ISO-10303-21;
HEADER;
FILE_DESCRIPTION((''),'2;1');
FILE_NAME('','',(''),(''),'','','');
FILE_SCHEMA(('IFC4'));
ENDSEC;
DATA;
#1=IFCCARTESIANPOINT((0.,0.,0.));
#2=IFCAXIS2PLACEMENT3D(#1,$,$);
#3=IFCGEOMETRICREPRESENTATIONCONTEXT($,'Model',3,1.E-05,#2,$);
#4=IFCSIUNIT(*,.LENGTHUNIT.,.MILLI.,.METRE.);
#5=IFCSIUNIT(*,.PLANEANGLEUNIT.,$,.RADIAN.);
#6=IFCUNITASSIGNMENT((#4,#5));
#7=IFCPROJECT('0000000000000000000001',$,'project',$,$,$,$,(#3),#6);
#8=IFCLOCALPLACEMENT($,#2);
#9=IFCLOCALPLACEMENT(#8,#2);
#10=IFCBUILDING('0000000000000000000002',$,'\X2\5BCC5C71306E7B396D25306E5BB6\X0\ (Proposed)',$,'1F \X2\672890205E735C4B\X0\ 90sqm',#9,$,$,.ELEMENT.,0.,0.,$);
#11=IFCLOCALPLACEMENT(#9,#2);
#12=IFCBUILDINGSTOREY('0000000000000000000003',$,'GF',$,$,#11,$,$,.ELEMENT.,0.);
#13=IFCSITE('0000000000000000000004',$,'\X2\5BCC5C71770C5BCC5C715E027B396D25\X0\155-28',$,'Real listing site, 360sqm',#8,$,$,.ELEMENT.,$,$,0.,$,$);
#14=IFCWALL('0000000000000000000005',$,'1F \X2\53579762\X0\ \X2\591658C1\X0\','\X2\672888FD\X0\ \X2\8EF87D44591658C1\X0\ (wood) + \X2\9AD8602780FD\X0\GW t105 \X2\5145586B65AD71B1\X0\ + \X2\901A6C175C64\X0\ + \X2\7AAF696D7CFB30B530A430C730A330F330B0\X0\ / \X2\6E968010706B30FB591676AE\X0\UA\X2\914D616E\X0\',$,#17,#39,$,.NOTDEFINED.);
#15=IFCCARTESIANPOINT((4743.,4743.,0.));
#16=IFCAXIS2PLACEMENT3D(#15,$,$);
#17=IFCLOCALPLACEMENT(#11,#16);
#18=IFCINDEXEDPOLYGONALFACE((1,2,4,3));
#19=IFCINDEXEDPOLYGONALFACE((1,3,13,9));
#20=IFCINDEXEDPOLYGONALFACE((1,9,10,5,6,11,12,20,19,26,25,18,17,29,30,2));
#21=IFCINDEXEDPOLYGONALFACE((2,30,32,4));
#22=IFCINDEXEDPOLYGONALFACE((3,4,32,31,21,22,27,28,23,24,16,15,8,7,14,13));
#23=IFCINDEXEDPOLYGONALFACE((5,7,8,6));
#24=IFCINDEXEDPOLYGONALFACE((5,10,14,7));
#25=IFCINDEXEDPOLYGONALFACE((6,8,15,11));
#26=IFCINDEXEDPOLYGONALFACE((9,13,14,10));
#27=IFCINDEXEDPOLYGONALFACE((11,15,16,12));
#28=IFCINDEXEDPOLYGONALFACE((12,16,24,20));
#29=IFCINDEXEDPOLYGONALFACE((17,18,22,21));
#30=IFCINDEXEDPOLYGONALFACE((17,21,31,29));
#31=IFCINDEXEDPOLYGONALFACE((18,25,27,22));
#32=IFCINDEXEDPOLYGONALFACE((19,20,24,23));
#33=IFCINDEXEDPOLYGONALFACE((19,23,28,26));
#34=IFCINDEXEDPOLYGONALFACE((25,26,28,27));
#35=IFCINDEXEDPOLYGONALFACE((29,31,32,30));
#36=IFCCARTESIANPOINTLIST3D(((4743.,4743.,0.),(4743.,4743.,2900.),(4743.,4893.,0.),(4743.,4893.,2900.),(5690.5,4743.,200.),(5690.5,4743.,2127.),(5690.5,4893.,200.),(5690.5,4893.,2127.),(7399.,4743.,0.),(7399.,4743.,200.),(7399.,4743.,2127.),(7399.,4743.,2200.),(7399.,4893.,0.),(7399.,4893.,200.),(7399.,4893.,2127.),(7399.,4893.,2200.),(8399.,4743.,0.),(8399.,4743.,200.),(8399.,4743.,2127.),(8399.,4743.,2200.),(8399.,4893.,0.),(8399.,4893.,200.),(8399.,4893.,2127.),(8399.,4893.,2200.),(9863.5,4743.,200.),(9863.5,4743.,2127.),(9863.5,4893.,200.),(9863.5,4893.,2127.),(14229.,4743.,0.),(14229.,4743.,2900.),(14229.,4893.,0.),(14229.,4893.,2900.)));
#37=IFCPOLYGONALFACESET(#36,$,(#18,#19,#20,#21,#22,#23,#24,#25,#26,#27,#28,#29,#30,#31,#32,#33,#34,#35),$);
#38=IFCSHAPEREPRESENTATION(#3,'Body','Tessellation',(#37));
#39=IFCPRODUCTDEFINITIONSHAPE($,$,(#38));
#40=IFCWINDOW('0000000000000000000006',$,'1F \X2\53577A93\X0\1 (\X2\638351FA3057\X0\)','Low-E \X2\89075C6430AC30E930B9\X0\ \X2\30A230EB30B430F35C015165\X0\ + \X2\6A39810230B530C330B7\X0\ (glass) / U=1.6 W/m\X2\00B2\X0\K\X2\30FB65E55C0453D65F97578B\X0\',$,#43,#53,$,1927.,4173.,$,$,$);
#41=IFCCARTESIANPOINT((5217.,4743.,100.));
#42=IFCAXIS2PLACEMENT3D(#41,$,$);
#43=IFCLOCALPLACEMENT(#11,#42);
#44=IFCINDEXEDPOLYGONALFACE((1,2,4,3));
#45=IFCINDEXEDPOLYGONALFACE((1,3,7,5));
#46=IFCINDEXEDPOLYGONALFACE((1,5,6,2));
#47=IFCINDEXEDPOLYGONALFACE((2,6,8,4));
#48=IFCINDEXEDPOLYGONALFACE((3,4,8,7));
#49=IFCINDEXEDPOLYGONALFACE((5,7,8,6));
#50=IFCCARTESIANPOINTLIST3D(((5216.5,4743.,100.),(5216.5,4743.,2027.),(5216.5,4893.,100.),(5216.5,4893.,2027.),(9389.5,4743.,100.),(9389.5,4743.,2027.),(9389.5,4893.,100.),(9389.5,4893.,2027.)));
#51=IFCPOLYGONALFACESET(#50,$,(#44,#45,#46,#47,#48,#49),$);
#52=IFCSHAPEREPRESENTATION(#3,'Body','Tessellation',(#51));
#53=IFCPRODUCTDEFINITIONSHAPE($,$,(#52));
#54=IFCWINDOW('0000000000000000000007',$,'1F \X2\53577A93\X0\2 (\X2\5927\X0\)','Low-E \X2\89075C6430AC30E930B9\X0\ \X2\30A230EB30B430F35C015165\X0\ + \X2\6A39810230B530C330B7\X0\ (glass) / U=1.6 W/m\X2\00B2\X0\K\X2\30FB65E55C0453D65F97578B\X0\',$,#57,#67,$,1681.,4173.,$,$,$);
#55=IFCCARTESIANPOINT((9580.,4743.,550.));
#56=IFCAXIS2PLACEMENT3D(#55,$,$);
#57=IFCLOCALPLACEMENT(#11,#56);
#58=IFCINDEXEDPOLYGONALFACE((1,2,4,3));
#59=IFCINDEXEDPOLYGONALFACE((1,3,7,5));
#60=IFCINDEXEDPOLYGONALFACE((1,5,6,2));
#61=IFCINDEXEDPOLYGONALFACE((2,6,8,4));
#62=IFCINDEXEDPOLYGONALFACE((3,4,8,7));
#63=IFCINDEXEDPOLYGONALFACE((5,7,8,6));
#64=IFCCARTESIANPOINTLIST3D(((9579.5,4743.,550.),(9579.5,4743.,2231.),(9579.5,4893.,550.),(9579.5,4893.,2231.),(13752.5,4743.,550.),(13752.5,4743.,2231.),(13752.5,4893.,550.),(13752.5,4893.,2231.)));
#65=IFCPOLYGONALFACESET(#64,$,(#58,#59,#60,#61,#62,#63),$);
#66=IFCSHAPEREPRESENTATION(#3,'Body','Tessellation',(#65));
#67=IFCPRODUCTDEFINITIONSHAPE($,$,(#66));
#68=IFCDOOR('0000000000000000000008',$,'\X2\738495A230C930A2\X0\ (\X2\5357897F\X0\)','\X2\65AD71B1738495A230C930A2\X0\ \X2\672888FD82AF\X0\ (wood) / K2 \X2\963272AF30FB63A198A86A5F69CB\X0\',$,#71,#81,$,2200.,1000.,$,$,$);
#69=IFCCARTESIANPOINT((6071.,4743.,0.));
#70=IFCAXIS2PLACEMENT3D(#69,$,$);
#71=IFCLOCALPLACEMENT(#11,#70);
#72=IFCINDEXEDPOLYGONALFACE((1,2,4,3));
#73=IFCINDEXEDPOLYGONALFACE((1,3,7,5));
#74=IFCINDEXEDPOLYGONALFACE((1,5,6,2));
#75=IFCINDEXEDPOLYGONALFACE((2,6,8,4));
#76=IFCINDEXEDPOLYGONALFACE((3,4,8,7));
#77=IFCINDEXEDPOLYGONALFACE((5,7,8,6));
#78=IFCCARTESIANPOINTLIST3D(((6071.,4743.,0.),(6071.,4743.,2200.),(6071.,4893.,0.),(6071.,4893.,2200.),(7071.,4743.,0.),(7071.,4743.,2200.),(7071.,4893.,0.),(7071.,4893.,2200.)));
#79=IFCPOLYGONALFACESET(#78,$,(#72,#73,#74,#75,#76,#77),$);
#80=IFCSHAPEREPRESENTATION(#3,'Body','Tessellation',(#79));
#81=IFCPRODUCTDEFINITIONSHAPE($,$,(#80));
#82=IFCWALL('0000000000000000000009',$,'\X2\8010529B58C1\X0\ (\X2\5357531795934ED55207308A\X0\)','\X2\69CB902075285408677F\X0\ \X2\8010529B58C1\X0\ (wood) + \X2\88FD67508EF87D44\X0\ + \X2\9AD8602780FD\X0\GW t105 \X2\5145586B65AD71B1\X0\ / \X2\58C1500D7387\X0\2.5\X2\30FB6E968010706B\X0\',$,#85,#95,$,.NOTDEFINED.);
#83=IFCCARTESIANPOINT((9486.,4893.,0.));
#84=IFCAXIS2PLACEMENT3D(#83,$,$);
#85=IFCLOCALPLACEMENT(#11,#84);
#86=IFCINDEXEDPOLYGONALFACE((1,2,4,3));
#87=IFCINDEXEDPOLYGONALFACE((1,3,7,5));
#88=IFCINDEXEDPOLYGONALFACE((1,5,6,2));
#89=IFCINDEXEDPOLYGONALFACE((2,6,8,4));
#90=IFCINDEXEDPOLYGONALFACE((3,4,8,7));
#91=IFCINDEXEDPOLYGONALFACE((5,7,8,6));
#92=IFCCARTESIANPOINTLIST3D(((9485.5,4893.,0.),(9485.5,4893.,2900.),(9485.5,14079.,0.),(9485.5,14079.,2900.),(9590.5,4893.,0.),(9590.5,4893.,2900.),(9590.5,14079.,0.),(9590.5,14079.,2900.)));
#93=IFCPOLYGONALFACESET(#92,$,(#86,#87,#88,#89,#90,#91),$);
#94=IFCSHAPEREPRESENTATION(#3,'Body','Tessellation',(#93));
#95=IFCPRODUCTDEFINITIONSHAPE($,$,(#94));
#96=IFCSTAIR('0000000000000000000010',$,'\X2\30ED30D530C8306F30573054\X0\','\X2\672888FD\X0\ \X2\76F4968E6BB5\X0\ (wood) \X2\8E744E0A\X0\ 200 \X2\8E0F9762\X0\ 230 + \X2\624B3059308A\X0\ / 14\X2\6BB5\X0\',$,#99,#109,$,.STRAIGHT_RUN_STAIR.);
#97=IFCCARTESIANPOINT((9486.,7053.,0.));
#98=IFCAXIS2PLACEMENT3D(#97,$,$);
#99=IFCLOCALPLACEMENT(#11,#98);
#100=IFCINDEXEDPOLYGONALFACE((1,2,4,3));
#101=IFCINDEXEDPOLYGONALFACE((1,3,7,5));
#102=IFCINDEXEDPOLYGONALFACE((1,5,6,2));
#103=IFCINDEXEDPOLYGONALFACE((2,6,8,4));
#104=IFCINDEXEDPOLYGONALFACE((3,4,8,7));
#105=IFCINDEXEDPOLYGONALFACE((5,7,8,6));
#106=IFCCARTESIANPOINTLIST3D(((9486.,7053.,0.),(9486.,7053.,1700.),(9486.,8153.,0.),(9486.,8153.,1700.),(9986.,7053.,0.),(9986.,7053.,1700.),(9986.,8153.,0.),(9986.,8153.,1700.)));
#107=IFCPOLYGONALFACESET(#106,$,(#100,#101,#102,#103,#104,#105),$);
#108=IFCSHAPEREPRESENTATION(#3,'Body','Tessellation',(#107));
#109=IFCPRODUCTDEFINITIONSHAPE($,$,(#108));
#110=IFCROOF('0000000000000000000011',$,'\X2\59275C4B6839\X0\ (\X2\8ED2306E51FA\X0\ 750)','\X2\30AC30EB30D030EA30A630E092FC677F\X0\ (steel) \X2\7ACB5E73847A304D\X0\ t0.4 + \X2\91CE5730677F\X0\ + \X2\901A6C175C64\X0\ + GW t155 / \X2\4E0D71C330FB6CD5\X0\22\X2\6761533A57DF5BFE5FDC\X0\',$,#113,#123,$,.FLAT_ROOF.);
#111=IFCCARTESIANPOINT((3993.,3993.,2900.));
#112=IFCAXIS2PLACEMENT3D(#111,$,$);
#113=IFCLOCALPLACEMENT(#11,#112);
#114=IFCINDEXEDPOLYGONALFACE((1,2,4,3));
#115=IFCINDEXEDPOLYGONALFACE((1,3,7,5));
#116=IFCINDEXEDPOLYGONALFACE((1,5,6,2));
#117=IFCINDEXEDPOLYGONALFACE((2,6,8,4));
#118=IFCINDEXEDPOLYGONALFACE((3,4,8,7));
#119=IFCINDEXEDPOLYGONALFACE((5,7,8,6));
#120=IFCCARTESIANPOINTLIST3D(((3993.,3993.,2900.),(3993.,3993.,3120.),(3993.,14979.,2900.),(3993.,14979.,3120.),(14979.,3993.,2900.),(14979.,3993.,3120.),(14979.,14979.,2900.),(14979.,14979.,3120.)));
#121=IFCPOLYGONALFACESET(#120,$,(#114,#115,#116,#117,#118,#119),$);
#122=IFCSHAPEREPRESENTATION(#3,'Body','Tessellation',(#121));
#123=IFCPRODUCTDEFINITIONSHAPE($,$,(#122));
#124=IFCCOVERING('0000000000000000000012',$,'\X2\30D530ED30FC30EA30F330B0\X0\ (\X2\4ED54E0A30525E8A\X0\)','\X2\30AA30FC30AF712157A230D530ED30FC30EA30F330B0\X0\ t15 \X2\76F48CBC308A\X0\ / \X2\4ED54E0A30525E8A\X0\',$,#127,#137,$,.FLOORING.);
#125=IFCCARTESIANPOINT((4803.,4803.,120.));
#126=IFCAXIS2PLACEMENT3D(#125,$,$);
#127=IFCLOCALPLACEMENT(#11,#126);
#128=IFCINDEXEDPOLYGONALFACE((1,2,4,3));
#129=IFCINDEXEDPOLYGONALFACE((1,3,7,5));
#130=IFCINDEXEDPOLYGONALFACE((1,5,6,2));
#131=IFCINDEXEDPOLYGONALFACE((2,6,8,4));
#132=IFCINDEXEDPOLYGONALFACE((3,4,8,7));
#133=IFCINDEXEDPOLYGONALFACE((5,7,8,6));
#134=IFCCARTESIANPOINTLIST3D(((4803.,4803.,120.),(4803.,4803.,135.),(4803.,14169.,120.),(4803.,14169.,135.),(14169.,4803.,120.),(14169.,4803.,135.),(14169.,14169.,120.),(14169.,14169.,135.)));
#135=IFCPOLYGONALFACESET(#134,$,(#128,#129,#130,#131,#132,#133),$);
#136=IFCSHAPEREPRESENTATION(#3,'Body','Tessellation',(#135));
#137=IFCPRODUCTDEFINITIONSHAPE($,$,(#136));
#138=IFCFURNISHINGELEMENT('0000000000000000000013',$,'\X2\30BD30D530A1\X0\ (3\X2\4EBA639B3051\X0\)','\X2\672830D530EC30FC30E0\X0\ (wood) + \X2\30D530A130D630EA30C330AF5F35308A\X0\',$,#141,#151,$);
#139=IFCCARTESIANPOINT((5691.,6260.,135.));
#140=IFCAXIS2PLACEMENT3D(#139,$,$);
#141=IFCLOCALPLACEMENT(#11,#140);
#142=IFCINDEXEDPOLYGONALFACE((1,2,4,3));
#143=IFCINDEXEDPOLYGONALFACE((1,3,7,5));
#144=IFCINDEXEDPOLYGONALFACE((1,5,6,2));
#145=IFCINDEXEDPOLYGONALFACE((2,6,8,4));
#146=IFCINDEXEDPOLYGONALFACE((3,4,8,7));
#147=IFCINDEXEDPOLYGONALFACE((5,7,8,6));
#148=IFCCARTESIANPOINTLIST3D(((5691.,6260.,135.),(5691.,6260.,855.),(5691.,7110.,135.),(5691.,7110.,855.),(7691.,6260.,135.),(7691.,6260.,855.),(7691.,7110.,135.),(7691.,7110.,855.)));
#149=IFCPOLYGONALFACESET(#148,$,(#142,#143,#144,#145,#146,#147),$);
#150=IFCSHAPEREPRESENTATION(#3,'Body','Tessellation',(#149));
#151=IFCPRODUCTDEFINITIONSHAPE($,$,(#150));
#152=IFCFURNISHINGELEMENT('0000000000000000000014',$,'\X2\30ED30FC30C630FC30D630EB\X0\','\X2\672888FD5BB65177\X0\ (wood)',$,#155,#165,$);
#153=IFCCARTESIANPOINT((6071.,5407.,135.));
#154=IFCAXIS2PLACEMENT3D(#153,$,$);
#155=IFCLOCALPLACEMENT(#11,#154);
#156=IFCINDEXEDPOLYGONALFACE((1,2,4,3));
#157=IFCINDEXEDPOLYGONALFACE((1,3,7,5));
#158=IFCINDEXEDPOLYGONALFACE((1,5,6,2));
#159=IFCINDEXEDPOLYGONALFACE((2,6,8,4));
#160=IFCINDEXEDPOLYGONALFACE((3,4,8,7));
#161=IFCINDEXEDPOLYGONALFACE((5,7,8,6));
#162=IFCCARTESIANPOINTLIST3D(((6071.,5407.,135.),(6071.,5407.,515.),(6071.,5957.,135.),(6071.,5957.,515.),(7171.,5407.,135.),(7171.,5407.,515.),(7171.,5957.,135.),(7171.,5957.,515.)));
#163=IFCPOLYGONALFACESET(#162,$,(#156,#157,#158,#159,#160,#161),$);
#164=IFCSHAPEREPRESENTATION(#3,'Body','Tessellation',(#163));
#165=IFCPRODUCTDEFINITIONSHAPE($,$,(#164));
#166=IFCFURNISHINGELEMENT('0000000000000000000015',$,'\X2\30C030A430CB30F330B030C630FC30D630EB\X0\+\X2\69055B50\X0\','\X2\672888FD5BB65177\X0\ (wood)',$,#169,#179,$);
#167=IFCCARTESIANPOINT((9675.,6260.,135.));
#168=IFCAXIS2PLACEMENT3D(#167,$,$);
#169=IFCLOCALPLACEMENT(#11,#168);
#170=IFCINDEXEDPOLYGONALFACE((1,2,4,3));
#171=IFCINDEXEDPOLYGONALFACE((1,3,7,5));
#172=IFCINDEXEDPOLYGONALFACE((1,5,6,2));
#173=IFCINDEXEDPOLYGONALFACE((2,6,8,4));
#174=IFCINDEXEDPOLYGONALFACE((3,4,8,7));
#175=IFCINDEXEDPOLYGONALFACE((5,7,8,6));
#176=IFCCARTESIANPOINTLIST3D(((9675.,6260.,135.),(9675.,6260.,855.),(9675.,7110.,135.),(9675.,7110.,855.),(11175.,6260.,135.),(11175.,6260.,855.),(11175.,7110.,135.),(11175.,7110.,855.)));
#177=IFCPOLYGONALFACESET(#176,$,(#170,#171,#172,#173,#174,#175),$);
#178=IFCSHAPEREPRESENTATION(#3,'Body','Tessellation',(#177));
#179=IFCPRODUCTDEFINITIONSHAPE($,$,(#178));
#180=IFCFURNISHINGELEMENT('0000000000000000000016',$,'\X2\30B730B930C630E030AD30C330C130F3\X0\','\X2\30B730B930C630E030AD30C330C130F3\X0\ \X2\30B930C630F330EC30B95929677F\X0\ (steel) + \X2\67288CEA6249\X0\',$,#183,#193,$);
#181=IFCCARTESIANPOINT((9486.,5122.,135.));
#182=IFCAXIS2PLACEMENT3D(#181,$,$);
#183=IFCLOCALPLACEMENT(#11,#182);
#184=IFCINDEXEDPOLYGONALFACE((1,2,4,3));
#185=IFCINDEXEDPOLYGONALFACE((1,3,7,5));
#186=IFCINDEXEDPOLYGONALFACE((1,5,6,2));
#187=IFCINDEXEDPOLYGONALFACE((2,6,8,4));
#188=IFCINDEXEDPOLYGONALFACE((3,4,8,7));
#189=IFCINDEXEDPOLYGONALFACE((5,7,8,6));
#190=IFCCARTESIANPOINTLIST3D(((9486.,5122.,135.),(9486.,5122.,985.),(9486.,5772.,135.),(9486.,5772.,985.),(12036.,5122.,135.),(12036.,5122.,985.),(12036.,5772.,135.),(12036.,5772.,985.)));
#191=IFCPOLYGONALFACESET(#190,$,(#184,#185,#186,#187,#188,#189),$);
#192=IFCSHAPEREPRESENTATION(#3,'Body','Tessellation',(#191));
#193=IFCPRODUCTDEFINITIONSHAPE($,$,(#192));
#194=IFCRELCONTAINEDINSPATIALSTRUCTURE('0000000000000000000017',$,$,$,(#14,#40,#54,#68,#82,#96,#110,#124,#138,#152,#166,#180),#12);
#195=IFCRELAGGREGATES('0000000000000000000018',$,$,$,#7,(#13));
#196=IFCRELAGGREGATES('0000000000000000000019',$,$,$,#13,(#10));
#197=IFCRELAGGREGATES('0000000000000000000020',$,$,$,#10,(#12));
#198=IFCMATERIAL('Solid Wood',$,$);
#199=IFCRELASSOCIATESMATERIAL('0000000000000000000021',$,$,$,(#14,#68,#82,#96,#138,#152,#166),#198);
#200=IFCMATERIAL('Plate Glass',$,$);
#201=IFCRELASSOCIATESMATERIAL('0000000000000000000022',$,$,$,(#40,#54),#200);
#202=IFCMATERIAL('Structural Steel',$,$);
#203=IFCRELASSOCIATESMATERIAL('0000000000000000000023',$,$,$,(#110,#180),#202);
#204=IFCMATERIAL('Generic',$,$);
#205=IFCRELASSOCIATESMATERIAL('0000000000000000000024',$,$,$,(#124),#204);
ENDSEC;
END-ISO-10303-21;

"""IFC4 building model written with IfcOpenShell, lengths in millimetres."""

from ifc_helpers import new_model, si_unit, frame, frame_2d, origin, place, context, project, spatial, rectangle, extrude, material, element, fill, save


model = new_model("IFC4")

# Units and contexts
model_context = context("Model", 3, precision=1e-05, world=origin())
ifc_project = project(units=[si_unit("LENGTHUNIT", "METRE", prefix="MILLI"), si_unit("PLANEANGLEUNIT", "RADIAN")], contexts=[model_context])

# Site, building, storey
site_placement = place(None, origin())
site = spatial("IfcSite", under=ifc_project, at=site_placement, Name="富山県富山市笹津155-28", ObjectType="Real listing site, 360sqm", CompositionType="ELEMENT", RefElevation=0.0)
building_placement = place(site_placement, origin())
building = spatial("IfcBuilding", under=site, at=building_placement, Name="富山の笹津の家 (Proposed)", ObjectType="1F 木造平屋 90sqm", CompositionType="ELEMENT", ElevationOfRefHeight=0.0, ElevationOfTerrain=0.0)
storey_placement = place(building_placement, origin())
storey = spatial("IfcBuildingStorey", under=building, at=storey_placement, Name="GF", CompositionType="ELEMENT", Elevation=0.0)

# Shared definitions
ifc_material_1 = material(Name="Solid Wood")

# Wall, openings, windows, door
wall_1_placement = place(storey_placement, frame((4743.0, 4743.0, 0.0)))
wall_1 = element("IfcWall", 1, at=wall_1_placement, inside=storey, material=ifc_material_1, Name="1F 南面 外壁", Description="木製 軸組外壁 (wood) + 高性能GW t105 充填断熱 + 通気層 + 窯業系サイディング / 準耐火・外皮UA配慮", PredefinedType="NOTDEFINED", context=model_context, shape_type="SweptSolid", body=[
    extrude(rectangle(XDim=9486.0, YDim=150.0, at=frame_2d((4743.0, 75.0))), frame((4743.0, 4743.0, 0.0)), (0.0, 0.0, 1.0), 2900.0),
])
opening_1_placement = place(storey_placement, frame((5217.0, 4743.0, 100.0)))
opening_1 = element("IfcOpeningElement", 2, at=opening_1_placement, cuts=wall_1, PredefinedType="NOTDEFINED", context=model_context, shape_type="SweptSolid", body=[
    extrude(rectangle(XDim=4173.0, YDim=150.0, at=frame_2d((2086.0, 75.0))), frame((5217.0, 4743.0, 100.0)), (0.0, 0.0, 1.0), 1927.0),
])
opening_2_placement = place(storey_placement, frame((9580.0, 4743.0, 550.0)))
opening_2 = element("IfcOpeningElement", 3, at=opening_2_placement, cuts=wall_1, PredefinedType="NOTDEFINED", context=model_context, shape_type="SweptSolid", body=[
    extrude(rectangle(XDim=4173.0, YDim=150.0, at=frame_2d((2086.0, 75.0))), frame((9580.0, 4743.0, 550.0)), (0.0, 0.0, 1.0), 1681.0),
])
opening_3_placement = place(storey_placement, frame((6071.0, 4743.0, 0.0)))
opening_3 = element("IfcOpeningElement", 4, at=opening_3_placement, cuts=wall_1, PredefinedType="NOTDEFINED", context=model_context, shape_type="SweptSolid", body=[
    extrude(rectangle(XDim=1000.0, YDim=150.0, at=frame_2d((500.0, 75.0))), frame((6071.0, 4743.0, 0.0)), (0.0, 0.0, 1.0), 2200.0),
])
ifc_material_2 = material(Name="Plate Glass")
window_1_placement = place(storey_placement, frame((5217.0, 4743.0, 100.0)))
window_1 = element("IfcWindow", 5, at=window_1_placement, inside=storey, material=ifc_material_2, Name="1F 南窓1 (掃出し)", Description="Low-E 複層ガラス アルゴン封入 + 樹脂サッシ (glass) / U=1.6 W/m²K・日射取得型", OverallHeight=1927.0, OverallWidth=4173.0, context=model_context, shape_type="SweptSolid", body=[
    extrude(rectangle(XDim=4173.0, YDim=150.0, at=frame_2d((2086.0, 75.0))), frame((5217.0, 4743.0, 100.0)), (0.0, 0.0, 1.0), 1927.0),
])
fill(opening_1, window_1)
window_2_placement = place(storey_placement, frame((9580.0, 4743.0, 550.0)))
window_2 = element("IfcWindow", 6, at=window_2_placement, inside=storey, material=ifc_material_2, Name="1F 南窓2 (大)", Description="Low-E 複層ガラス アルゴン封入 + 樹脂サッシ (glass) / U=1.6 W/m²K・日射取得型", OverallHeight=1681.0, OverallWidth=4173.0, context=model_context, shape_type="SweptSolid", body=[
    extrude(rectangle(XDim=4173.0, YDim=150.0, at=frame_2d((2086.0, 75.0))), frame((9580.0, 4743.0, 550.0)), (0.0, 0.0, 1.0), 1681.0),
])
fill(opening_2, window_2)
door_placement = place(storey_placement, frame((6071.0, 4743.0, 0.0)))
door = element("IfcDoor", 7, at=door_placement, inside=storey, material=ifc_material_1, Name="玄関ドア (南西)", Description="断熱玄関ドア 木製芯 (wood) / K2 防犯・採風機構", OverallHeight=2200.0, OverallWidth=1000.0, context=model_context, shape_type="SweptSolid", body=[
    extrude(rectangle(XDim=1000.0, YDim=150.0, at=frame_2d((500.0, 75.0))), frame((6071.0, 4743.0, 0.0)), (0.0, 0.0, 1.0), 2200.0),
])
fill(opening_3, door)

# Wall
wall_2_placement = place(storey_placement, frame((9486.0, 4893.0, 0.0)))
element("IfcWall", 8, at=wall_2_placement, inside=storey, material=ifc_material_1, Name="耐力壁 (南北間仕切り)", Description="構造用合板 耐力壁 (wood) + 製材軸組 + 高性能GW t105 充填断熱 / 壁倍率2.5・準耐火", PredefinedType="NOTDEFINED", context=model_context, shape_type="SweptSolid", body=[
    extrude(rectangle(XDim=105.0, YDim=9186.0, at=frame_2d((52.0, 4593.0))), frame((9486.0, 4893.0, 0.0)), (0.0, 0.0, 1.0), 2900.0),
])

# Stair
stair_placement = place(storey_placement, frame((9486.0, 7053.0, 0.0)))
element("IfcStair", 9, at=stair_placement, inside=storey, material=ifc_material_1, Name="ロフトはしご", Description="木製 直階段 (wood) 蹴上 200 踏面 230 + 手すり / 14段", PredefinedType="STRAIGHT_RUN_STAIR", context=model_context, shape_type="SweptSolid", body=[
    extrude(rectangle(XDim=500.0, YDim=1100.0, at=frame_2d((250.0, 550.0))), frame((9486.0, 7053.0, 0.0)), (0.0, 0.0, 1.0), 1700.0),
])

# Roof
ifc_material_3 = material(Name="Structural Steel")
roof_placement = place(storey_placement, frame((3993.0, 3993.0, 2900.0)))
element("IfcRoof", 10, at=roof_placement, inside=storey, material=ifc_material_3, Name="大屋根 (軒の出 750)", Description="ガルバリウム鋼板 (steel) 立平葺き t0.4 + 野地板 + 通気層 + GW t155 / 不燃・法22条区域対応", PredefinedType="FLAT_ROOF", context=model_context, shape_type="SweptSolid", body=[
    extrude(rectangle(XDim=10986.0, YDim=10986.0, at=frame_2d((5493.0, 5493.0))), frame((3993.0, 3993.0, 2900.0)), (0.0, 0.0, 1.0), 220.0),
])

# Covering
ifc_material_4 = material(Name="Generic")
covering_placement = place(storey_placement, frame((4803.0, 4803.0, 120.0)))
element("IfcCovering", 11, at=covering_placement, inside=storey, material=ifc_material_4, Name="フローリング (仕上げ床)", Description="オーク無垢フローリング t15 直貼り / 仕上げ床", PredefinedType="FLOORING", context=model_context, shape_type="SweptSolid", body=[
    extrude(rectangle(XDim=9366.0, YDim=9366.0, at=frame_2d((4683.0, 4683.0))), frame((4803.0, 4803.0, 120.0)), (0.0, 0.0, 1.0), 15.0),
])

# Furnishing elements
furnishing_1_placement = place(storey_placement, frame((5691.0, 6260.0, 135.0)))
element("IfcFurnishingElement", 12, at=furnishing_1_placement, inside=storey, material=ifc_material_1, Name="ソファ (3人掛け)", Description="木フレーム (wood) + ファブリック張り", context=model_context, shape_type="SweptSolid", body=[
    extrude(rectangle(XDim=2000.0, YDim=850.0, at=frame_2d((1000.0, 425.0))), frame((5691.0, 6260.0, 135.0)), (0.0, 0.0, 1.0), 720.0),
])
furnishing_2_placement = place(storey_placement, frame((6071.0, 5407.0, 135.0)))
element("IfcFurnishingElement", 13, at=furnishing_2_placement, inside=storey, material=ifc_material_1, Name="ローテーブル", Description="木製家具 (wood)", context=model_context, shape_type="SweptSolid", body=[
    extrude(rectangle(XDim=1100.0, YDim=550.0, at=frame_2d((550.0, 275.0))), frame((6071.0, 5407.0, 135.0)), (0.0, 0.0, 1.0), 380.0),
])
furnishing_3_placement = place(storey_placement, frame((9675.0, 6260.0, 135.0)))
element("IfcFurnishingElement", 14, at=furnishing_3_placement, inside=storey, material=ifc_material_1, Name="ダイニングテーブル+椅子", Description="木製家具 (wood)", context=model_context, shape_type="SweptSolid", body=[
    extrude(rectangle(XDim=1500.0, YDim=850.0, at=frame_2d((750.0, 425.0))), frame((9675.0, 6260.0, 135.0)), (0.0, 0.0, 1.0), 720.0),
])
furnishing_4_placement = place(storey_placement, frame((9486.0, 5122.0, 135.0)))
element("IfcFurnishingElement", 15, at=furnishing_4_placement, inside=storey, material=ifc_material_3, Name="システムキッチン", Description="システムキッチン ステンレス天板 (steel) + 木質扉", context=model_context, shape_type="SweptSolid", body=[
    extrude(rectangle(XDim=2550.0, YDim=650.0, at=frame_2d((1275.0, 325.0))), frame((9486.0, 5122.0, 135.0)), (0.0, 0.0, 1.0), 850.0),
])

save(model, "model.ifc")
